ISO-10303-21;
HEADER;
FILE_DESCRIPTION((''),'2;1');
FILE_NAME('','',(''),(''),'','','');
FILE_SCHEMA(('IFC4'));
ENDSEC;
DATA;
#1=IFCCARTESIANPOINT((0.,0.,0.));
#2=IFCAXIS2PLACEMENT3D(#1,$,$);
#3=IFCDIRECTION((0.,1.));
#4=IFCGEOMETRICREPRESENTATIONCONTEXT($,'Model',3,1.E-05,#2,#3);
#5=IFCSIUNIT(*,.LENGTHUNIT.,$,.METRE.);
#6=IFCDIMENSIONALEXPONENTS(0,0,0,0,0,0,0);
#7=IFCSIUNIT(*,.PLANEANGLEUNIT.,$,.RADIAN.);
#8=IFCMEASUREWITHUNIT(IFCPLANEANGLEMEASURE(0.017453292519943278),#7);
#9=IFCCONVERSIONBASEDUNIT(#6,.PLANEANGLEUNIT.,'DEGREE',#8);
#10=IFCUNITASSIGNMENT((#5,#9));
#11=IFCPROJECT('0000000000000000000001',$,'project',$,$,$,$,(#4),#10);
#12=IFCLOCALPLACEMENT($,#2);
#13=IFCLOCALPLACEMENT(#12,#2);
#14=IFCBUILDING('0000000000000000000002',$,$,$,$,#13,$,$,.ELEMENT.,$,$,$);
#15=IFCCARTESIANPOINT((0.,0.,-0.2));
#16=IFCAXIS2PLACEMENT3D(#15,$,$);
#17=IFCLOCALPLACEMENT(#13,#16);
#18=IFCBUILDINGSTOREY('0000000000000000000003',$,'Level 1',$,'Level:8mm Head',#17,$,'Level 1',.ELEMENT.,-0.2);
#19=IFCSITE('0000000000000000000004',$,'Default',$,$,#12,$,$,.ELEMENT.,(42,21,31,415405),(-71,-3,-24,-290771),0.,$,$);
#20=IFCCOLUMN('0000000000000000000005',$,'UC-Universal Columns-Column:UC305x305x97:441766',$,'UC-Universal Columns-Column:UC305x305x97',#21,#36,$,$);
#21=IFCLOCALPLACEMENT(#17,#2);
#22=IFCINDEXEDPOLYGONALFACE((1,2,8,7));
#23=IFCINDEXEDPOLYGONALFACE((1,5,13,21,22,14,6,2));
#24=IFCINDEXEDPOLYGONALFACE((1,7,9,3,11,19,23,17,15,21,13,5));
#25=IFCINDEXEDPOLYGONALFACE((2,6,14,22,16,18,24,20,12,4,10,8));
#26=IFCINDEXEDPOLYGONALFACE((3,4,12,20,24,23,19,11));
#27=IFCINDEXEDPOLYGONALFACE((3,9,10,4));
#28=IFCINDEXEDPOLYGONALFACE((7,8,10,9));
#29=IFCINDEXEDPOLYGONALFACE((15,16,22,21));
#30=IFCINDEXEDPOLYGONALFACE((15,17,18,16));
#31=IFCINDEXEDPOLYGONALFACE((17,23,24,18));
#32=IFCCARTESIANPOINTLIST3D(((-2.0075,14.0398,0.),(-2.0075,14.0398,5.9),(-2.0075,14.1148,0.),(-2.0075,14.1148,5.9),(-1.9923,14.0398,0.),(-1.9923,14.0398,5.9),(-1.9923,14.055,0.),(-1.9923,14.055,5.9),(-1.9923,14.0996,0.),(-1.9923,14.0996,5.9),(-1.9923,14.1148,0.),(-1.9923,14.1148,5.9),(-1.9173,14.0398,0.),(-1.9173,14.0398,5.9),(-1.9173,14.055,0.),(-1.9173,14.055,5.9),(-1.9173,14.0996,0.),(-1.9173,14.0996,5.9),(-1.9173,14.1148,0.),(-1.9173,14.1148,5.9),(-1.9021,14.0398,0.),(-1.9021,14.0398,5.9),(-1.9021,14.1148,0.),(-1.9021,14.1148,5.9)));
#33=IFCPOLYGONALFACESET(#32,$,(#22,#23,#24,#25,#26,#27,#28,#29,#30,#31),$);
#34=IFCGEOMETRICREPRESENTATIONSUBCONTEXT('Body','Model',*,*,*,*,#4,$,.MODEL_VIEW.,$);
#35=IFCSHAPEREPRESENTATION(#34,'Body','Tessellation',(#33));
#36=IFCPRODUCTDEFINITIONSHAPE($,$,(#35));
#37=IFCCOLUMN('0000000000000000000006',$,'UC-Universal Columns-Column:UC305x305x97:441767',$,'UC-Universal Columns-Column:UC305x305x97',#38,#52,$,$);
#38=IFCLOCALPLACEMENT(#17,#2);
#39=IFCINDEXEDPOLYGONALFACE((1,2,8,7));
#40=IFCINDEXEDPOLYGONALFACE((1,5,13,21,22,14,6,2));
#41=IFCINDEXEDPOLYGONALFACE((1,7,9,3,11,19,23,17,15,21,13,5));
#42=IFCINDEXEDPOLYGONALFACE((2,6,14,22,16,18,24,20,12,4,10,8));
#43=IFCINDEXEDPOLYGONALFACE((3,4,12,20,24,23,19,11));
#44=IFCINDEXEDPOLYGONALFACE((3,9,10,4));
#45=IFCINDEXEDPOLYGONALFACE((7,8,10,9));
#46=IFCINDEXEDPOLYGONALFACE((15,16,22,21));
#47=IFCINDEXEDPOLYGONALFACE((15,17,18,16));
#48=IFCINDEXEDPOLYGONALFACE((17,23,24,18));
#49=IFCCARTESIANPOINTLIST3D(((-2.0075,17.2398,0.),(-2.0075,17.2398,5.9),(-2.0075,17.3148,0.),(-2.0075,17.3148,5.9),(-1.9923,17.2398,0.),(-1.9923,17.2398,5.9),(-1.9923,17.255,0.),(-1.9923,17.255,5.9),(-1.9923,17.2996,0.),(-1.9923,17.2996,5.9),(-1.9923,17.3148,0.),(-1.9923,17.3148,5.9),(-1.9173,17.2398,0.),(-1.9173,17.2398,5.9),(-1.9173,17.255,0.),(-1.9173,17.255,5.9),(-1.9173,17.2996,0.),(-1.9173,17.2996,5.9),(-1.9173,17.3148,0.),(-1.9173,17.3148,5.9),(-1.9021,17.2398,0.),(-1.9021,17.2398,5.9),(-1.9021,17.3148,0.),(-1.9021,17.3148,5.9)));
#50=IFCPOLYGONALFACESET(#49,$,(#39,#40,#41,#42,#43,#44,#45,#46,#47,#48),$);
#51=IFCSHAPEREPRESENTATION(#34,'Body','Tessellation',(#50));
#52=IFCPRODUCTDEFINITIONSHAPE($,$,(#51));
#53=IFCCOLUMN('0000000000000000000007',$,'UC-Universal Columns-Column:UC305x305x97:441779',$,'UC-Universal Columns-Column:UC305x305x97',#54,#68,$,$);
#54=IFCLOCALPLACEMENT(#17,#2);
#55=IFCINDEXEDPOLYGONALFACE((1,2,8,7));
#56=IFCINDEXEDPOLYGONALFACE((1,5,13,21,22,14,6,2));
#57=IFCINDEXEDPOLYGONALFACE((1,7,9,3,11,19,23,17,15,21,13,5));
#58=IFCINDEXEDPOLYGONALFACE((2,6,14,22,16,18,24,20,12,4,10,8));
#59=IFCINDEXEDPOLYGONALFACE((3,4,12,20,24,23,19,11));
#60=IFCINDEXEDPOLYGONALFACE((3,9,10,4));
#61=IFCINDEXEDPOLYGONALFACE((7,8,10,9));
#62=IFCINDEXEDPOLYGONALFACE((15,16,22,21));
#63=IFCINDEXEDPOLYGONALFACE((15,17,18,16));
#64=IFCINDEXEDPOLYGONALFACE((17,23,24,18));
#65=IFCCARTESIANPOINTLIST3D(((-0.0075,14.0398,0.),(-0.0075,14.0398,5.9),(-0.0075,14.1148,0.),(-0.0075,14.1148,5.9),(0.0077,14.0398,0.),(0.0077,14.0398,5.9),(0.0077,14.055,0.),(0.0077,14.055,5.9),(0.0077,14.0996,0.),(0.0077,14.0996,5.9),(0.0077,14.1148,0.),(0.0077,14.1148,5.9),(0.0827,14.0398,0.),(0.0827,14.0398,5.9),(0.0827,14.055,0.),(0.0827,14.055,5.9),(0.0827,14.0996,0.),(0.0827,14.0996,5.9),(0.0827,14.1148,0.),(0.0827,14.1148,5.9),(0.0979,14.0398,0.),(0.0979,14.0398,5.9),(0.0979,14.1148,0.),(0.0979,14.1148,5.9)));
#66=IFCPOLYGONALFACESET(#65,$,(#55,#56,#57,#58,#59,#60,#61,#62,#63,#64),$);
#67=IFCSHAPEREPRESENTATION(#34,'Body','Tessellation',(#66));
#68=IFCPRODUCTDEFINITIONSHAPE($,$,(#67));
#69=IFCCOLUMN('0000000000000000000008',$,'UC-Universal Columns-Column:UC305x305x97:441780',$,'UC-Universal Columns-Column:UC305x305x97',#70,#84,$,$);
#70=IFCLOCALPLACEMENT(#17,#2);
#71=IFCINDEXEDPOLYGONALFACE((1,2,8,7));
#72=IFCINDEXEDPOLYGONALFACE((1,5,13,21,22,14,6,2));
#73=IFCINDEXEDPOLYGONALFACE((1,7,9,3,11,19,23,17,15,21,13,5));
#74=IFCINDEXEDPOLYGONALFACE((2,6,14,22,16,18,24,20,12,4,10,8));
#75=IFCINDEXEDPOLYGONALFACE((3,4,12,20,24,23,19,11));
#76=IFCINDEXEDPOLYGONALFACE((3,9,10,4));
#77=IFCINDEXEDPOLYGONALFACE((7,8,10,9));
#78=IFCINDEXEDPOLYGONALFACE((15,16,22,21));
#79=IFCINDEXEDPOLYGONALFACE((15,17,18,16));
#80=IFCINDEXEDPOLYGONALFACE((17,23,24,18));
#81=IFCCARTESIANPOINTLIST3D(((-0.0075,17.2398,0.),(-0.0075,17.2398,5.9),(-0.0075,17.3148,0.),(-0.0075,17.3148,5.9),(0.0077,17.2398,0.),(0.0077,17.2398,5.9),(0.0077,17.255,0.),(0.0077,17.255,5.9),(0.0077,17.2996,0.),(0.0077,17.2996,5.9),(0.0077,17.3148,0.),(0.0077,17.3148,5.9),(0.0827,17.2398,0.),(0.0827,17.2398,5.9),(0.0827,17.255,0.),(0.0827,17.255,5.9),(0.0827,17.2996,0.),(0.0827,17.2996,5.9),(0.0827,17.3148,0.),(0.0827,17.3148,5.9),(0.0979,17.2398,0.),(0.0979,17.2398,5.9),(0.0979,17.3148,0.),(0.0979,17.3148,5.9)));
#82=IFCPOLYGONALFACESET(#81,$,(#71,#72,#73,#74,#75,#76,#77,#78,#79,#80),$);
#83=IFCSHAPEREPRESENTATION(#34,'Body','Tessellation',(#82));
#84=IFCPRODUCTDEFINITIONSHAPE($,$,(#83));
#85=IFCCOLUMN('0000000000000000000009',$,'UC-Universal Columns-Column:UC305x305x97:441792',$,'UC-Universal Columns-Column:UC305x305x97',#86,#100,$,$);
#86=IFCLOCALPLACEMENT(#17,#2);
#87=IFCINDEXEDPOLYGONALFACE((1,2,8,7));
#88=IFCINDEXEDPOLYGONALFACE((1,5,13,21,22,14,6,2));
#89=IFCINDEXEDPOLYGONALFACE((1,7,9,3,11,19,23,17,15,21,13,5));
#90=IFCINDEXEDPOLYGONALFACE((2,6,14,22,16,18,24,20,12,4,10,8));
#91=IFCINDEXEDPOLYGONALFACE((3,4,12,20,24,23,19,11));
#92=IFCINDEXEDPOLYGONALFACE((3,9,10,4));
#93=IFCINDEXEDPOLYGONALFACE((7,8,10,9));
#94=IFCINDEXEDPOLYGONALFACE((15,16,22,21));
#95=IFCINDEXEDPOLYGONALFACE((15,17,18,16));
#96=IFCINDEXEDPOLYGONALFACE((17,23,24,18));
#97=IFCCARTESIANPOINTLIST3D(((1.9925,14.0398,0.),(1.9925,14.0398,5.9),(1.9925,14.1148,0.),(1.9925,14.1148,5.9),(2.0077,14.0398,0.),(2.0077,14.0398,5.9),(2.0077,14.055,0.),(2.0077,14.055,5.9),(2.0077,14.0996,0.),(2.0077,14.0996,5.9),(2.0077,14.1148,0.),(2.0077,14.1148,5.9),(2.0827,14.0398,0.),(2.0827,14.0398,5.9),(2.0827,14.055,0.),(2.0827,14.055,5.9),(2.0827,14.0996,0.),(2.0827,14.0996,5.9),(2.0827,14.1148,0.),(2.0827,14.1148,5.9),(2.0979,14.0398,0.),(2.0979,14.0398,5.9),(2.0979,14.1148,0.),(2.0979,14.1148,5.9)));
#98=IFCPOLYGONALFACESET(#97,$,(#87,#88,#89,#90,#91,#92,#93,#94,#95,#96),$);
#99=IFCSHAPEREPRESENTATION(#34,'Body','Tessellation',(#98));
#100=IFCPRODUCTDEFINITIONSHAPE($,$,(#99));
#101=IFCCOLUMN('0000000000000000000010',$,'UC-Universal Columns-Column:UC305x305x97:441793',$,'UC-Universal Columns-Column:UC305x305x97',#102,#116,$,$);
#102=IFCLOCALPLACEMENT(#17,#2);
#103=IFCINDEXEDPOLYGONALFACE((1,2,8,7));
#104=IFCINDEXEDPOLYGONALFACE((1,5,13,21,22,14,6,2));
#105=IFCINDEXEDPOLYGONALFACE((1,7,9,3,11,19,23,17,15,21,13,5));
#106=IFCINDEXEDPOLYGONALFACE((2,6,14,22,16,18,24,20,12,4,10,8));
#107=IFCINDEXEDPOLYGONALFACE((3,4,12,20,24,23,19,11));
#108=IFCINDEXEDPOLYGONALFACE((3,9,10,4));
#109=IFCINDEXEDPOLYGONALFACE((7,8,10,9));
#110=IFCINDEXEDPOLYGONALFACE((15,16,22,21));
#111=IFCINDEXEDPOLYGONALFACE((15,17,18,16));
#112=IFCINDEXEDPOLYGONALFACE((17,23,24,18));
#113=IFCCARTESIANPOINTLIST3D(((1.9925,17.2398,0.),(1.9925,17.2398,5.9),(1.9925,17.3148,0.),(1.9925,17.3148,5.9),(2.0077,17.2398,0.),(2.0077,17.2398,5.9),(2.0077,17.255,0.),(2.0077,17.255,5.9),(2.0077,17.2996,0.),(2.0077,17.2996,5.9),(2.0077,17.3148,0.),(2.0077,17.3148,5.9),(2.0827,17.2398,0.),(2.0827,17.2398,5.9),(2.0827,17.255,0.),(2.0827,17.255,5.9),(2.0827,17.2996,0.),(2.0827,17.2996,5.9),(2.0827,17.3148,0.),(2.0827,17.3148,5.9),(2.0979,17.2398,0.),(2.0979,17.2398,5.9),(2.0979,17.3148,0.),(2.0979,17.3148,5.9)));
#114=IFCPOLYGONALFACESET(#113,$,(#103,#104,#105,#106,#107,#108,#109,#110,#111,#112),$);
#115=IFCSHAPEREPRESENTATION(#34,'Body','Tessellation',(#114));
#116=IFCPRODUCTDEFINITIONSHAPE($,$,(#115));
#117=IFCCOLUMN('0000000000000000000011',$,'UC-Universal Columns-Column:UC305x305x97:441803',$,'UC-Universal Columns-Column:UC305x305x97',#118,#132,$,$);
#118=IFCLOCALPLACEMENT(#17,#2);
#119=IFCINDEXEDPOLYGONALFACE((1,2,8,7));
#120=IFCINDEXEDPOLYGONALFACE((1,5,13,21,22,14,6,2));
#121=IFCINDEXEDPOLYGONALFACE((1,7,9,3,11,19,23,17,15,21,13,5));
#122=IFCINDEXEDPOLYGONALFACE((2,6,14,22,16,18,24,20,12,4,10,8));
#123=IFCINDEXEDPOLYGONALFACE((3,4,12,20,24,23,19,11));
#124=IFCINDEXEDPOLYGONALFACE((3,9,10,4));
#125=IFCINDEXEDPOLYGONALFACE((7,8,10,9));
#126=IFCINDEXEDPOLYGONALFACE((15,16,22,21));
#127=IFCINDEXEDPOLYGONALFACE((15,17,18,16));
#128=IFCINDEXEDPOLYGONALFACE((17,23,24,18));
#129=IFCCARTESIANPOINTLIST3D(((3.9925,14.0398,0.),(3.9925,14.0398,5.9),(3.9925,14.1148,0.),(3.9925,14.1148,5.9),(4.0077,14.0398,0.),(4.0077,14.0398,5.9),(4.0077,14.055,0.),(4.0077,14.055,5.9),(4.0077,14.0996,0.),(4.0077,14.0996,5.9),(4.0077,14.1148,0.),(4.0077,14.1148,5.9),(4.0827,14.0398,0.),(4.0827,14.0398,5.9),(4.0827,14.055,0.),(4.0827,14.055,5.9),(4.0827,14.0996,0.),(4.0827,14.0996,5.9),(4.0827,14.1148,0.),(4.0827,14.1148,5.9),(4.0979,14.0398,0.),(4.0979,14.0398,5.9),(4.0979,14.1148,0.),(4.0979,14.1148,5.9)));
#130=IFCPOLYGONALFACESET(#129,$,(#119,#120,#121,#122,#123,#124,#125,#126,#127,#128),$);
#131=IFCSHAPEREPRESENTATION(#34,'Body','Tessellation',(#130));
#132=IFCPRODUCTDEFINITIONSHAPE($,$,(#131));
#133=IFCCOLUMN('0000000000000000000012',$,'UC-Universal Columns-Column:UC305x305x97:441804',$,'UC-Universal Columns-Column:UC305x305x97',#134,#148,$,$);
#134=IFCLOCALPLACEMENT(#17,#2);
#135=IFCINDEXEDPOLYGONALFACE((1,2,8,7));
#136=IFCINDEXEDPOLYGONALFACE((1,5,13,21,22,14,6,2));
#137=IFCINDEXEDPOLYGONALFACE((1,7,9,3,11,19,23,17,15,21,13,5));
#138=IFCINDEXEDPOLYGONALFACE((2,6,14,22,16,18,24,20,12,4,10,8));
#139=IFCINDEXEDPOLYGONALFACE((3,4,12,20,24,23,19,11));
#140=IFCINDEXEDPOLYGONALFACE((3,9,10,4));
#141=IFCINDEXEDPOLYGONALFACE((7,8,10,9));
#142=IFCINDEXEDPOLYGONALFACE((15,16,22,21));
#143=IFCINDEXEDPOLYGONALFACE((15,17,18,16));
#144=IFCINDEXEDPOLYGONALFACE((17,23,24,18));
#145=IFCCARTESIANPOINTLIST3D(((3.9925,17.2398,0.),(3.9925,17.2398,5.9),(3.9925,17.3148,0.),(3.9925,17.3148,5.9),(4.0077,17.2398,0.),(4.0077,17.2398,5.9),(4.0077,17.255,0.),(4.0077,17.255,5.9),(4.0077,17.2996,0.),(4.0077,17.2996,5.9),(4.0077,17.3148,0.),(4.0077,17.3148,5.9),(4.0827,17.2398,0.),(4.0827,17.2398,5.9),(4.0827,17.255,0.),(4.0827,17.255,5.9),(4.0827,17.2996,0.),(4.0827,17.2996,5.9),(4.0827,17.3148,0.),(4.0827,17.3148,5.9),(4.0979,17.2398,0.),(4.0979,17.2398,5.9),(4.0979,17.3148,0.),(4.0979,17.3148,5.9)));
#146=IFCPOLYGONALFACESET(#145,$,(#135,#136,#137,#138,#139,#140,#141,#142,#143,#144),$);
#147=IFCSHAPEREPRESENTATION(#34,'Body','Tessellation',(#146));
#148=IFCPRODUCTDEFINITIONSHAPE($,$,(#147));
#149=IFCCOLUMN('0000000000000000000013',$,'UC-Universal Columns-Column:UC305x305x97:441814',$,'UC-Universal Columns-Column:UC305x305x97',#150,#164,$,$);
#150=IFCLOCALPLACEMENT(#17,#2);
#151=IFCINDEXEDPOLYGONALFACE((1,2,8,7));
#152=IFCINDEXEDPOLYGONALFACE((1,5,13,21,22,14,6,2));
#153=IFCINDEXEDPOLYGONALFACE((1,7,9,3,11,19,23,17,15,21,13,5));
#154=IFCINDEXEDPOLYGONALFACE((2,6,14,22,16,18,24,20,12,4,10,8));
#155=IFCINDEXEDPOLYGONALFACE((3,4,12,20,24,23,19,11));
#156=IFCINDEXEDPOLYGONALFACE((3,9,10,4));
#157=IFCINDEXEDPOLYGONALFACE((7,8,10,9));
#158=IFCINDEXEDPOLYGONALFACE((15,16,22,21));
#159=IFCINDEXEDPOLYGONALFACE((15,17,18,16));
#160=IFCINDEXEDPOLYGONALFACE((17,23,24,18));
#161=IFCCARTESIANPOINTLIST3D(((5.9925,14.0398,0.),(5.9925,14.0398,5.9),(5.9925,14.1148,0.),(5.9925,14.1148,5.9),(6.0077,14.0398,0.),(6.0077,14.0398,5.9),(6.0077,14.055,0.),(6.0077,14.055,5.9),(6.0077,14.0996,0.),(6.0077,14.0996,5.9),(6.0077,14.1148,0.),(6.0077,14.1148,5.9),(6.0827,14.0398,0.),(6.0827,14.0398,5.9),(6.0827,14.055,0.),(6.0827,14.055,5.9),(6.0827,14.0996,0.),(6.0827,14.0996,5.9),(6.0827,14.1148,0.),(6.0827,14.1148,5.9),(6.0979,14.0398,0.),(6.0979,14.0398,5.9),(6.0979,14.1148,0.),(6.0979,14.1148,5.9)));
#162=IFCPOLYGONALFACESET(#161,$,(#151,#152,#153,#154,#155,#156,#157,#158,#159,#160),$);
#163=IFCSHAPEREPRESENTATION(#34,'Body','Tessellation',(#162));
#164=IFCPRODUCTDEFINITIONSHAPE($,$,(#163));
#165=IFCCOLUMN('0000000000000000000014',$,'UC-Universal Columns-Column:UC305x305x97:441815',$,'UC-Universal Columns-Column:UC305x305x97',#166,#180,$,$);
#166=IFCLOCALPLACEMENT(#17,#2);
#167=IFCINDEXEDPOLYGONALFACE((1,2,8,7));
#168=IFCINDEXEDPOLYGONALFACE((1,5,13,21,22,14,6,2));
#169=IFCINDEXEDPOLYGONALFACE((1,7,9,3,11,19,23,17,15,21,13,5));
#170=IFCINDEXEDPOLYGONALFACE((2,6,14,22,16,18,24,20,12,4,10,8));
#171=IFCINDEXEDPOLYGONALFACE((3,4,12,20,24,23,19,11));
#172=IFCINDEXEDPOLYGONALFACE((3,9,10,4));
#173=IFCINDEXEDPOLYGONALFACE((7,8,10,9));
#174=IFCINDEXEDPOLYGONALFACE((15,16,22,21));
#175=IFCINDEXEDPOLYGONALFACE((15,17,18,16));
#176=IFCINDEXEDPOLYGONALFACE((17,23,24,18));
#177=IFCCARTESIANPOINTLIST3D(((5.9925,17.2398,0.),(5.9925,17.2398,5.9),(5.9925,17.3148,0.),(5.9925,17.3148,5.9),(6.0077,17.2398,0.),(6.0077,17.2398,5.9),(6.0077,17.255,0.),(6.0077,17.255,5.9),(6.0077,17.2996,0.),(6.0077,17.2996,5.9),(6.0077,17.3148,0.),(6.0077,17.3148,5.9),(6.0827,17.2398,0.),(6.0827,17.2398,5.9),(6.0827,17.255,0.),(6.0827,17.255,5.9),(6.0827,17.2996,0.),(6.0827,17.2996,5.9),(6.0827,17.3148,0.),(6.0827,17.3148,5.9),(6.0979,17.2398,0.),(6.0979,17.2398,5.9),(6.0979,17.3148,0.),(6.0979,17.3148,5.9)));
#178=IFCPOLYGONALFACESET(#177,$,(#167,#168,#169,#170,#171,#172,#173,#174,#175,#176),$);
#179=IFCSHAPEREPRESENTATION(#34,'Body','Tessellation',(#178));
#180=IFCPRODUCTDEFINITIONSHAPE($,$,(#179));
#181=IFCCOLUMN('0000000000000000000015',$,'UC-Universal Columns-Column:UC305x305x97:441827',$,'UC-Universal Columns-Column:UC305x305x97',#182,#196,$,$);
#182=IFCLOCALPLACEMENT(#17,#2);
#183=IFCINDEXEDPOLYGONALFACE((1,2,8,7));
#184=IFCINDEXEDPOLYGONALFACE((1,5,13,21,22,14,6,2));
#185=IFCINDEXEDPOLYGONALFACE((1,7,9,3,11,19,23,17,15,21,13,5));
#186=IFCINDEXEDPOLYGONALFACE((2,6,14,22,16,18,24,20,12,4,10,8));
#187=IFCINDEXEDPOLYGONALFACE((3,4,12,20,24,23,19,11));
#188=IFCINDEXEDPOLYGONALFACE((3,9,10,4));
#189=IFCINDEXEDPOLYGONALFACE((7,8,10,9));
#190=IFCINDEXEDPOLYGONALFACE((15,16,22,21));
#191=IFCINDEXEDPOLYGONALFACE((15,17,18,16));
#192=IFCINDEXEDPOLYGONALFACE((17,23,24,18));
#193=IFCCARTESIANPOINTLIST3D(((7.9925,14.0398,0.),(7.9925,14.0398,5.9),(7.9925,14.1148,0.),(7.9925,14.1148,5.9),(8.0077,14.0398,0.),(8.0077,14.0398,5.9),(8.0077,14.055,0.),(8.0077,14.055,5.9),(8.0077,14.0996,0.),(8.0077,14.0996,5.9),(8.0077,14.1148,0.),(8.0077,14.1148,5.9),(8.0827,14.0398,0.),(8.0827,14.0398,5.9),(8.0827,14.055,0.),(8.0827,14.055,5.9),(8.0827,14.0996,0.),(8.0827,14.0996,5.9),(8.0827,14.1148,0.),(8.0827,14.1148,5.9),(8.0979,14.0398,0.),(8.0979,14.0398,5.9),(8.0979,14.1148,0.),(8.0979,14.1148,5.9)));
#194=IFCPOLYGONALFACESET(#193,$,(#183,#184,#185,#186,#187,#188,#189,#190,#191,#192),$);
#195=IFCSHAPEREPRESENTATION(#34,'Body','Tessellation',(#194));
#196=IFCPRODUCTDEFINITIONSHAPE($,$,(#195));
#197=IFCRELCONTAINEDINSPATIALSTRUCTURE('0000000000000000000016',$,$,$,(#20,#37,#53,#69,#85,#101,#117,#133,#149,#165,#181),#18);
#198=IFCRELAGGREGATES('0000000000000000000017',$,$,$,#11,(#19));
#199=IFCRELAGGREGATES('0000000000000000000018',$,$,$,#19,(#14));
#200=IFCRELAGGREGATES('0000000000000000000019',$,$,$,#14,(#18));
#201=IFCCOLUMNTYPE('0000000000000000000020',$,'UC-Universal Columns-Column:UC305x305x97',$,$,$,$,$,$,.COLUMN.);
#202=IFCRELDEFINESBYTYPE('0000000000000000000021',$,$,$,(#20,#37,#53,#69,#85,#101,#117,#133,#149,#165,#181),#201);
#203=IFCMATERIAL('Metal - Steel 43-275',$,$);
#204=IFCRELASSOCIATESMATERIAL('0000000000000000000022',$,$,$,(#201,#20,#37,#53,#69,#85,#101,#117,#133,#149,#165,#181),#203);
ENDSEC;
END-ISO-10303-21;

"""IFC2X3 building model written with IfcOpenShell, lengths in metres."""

from ifc_helpers import new_model, entity, si_unit, converted_unit, direction, frame, frame_2d, origin, place, context, subcontext, project, spatial, polyline, circle_curve, parameter, trimmed, segment, composite_curve, outline, extrude, source, transform, mapped, material, type_object, type_shapes, element, save


model = new_model("IFC2X3")

# Units and contexts
model_context = context("Model", 3, precision=1e-05, world=origin(), true_north=direction((0.0, 1.0)))
body_context = subcontext(model_context, "Body", "Model", "MODEL_VIEW")
ifc_project = project(units=[si_unit("LENGTHUNIT", "METRE"), converted_unit("PLANEANGLEUNIT", "DEGREE", entity("IfcPlaneAngleMeasure", 0.017453292519943278), si_unit("PLANEANGLEUNIT", "RADIAN"), dimensions=[0, 0, 0, 0, 0, 0, 0])], contexts=[model_context])

# Site, building, storey
site_placement = place(None, origin())
site = spatial("IfcSite", under=ifc_project, at=site_placement, Name="Default", CompositionType="ELEMENT", RefLatitude=(42, 21, 31, 415405), RefLongitude=(-71, -3, -24, -290771), RefElevation=0.0)
building_placement = place(site_placement, origin())
building = spatial("IfcBuilding", under=site, at=building_placement, CompositionType="ELEMENT")
storey_placement = place(building_placement, frame((0.0, 0.0, -0.2)))
storey = spatial("IfcBuildingStorey", under=building, at=storey_placement, Name="Level 1", ObjectType="Level:8mm Head", LongName="Level 1", CompositionType="ELEMENT", Elevation=-0.2)

# Columns
ifc_material = material(Name="Metal - Steel 43-275")
column_type = type_object("IfcColumnType", Name="UC-Universal Columns-Column:UC305x305x97", PredefinedType="COLUMN", material=ifc_material)
shared_shape = source(origin(), body_context, "Body", "SweptSolid", [
    extrude(outline(composite_curve([segment(polyline([(-0.0375, -0.0375), (0.0375, -0.0375)]), True, "CONTINUOUS"), segment(polyline([(0.0375, -0.0375), (0.0527, -0.0375)]), True, "CONTINUOUS"), segment(trimmed(circle_curve(frame_2d((0.0527, -0.0223), x_axis=(-1.0, 0.0)), 0.0152), [parameter(0.0)], [parameter(90.0)], True, "PARAMETER"), False, "CONTINUOUS"), segment(polyline([(0.0375, -0.0223), (0.0375, 0.0223)]), True, "CONTINUOUS"), segment(trimmed(circle_curve(frame_2d((0.0527, 0.0223), x_axis=(-1.0, 0.0)), 0.0152), [parameter(270.0)], [parameter(0.0)], True, "PARAMETER"), False, "CONTINUOUS"), segment(polyline([(0.0527, 0.0375), (0.0375, 0.0375)]), True, "CONTINUOUS"), segment(polyline([(0.0375, 0.0375), (-0.0375, 0.0375)]), True, "CONTINUOUS"), segment(polyline([(-0.0375, 0.0375), (-0.0527, 0.0375)]), True, "CONTINUOUS"), segment(trimmed(circle_curve(frame_2d((-0.0527, 0.0223), x_axis=(-1.0, 0.0)), 0.0152), [parameter(180.0)], [parameter(270.0)], True, "PARAMETER"), False, "CONTINUOUS"), segment(polyline([(-0.0375, 0.0223), (-0.0375, -0.0223)]), True, "CONTINUOUS"), segment(trimmed(circle_curve(frame_2d((-0.0527, -0.0223), x_axis=(-1.0, 0.0)), 0.0152), [parameter(90.0)], [parameter(180.0)], True, "PARAMETER"), False, "CONTINUOUS"), segment(polyline([(-0.0527, -0.0375), (-0.0375, -0.0375)]), True, "CONTINUOUS")], self_intersect=False)), frame((0.0, 0.0, -0.2), z_axis=(0.0, 0.0, 1.0), x_axis=(-1.0, 0.0, 0.0)), (0.0, 0.0, 1.0), 5.9),
])
type_shapes(column_type, [shared_shape])
for number, where, z_axis, x_axis, name in (
    (1, (-1.9548, 14.0773, 0.2), (0.0, 0.0, 1.0), (-1.0, 0.0, 0.0), "UC-Universal Columns-Column:UC305x305x97:441766"),
    (2, (-1.9548, 17.2773, 0.2), (0.0, 0.0, 1.0), (-1.0, 0.0, 0.0), "UC-Universal Columns-Column:UC305x305x97:441767"),
    (3, (0.0452, 14.0773, 0.2), (0.0, 0.0, 1.0), (-1.0, 0.0, 0.0), "UC-Universal Columns-Column:UC305x305x97:441779"),
    (4, (0.0452, 17.2773, 0.2), (0.0, 0.0, 1.0), (-1.0, 0.0, 0.0), "UC-Universal Columns-Column:UC305x305x97:441780"),
    (5, (2.0452, 14.0773, 0.2), (0.0, 0.0, 1.0), (-1.0, 0.0, 0.0), "UC-Universal Columns-Column:UC305x305x97:441792"),
    (6, (2.0452, 17.2773, 0.2), (0.0, 0.0, 1.0), (-1.0, 0.0, 0.0), "UC-Universal Columns-Column:UC305x305x97:441793"),
    (7, (4.0452, 14.0773, 0.2), (0.0, 0.0, 1.0), (-1.0, 0.0, 0.0), "UC-Universal Columns-Column:UC305x305x97:441803"),
    (8, (4.0452, 17.2773, 0.2), (0.0, 0.0, 1.0), (-1.0, 0.0, 0.0), "UC-Universal Columns-Column:UC305x305x97:441804"),
    (9, (6.0452, 14.0773, 0.2), (0.0, 0.0, 1.0), (-1.0, 0.0, 0.0), "UC-Universal Columns-Column:UC305x305x97:441814"),
    (10, (6.0452, 17.2773, 0.2), (0.0, 0.0, 1.0), (-1.0, 0.0, 0.0), "UC-Universal Columns-Column:UC305x305x97:441815"),
    (11, (8.0452, 14.0773, 0.2), (0.0, 0.0, 1.0), (-1.0, 0.0, 0.0), "UC-Universal Columns-Column:UC305x305x97:441827"),
):
    element("IfcColumn", number, at=place(storey_placement, frame(where, z_axis=z_axis, x_axis=x_axis)), inside=storey, type_object=column_type, material=ifc_material, Name=name, ObjectType="UC-Universal Columns-Column:UC305x305x97", context=body_context, shape_type="MappedRepresentation", body=[
        mapped(shared_shape, transform((0.0, 0.0, 0.0), scale=1.0)),
    ])

save(model, "model.ifc")
